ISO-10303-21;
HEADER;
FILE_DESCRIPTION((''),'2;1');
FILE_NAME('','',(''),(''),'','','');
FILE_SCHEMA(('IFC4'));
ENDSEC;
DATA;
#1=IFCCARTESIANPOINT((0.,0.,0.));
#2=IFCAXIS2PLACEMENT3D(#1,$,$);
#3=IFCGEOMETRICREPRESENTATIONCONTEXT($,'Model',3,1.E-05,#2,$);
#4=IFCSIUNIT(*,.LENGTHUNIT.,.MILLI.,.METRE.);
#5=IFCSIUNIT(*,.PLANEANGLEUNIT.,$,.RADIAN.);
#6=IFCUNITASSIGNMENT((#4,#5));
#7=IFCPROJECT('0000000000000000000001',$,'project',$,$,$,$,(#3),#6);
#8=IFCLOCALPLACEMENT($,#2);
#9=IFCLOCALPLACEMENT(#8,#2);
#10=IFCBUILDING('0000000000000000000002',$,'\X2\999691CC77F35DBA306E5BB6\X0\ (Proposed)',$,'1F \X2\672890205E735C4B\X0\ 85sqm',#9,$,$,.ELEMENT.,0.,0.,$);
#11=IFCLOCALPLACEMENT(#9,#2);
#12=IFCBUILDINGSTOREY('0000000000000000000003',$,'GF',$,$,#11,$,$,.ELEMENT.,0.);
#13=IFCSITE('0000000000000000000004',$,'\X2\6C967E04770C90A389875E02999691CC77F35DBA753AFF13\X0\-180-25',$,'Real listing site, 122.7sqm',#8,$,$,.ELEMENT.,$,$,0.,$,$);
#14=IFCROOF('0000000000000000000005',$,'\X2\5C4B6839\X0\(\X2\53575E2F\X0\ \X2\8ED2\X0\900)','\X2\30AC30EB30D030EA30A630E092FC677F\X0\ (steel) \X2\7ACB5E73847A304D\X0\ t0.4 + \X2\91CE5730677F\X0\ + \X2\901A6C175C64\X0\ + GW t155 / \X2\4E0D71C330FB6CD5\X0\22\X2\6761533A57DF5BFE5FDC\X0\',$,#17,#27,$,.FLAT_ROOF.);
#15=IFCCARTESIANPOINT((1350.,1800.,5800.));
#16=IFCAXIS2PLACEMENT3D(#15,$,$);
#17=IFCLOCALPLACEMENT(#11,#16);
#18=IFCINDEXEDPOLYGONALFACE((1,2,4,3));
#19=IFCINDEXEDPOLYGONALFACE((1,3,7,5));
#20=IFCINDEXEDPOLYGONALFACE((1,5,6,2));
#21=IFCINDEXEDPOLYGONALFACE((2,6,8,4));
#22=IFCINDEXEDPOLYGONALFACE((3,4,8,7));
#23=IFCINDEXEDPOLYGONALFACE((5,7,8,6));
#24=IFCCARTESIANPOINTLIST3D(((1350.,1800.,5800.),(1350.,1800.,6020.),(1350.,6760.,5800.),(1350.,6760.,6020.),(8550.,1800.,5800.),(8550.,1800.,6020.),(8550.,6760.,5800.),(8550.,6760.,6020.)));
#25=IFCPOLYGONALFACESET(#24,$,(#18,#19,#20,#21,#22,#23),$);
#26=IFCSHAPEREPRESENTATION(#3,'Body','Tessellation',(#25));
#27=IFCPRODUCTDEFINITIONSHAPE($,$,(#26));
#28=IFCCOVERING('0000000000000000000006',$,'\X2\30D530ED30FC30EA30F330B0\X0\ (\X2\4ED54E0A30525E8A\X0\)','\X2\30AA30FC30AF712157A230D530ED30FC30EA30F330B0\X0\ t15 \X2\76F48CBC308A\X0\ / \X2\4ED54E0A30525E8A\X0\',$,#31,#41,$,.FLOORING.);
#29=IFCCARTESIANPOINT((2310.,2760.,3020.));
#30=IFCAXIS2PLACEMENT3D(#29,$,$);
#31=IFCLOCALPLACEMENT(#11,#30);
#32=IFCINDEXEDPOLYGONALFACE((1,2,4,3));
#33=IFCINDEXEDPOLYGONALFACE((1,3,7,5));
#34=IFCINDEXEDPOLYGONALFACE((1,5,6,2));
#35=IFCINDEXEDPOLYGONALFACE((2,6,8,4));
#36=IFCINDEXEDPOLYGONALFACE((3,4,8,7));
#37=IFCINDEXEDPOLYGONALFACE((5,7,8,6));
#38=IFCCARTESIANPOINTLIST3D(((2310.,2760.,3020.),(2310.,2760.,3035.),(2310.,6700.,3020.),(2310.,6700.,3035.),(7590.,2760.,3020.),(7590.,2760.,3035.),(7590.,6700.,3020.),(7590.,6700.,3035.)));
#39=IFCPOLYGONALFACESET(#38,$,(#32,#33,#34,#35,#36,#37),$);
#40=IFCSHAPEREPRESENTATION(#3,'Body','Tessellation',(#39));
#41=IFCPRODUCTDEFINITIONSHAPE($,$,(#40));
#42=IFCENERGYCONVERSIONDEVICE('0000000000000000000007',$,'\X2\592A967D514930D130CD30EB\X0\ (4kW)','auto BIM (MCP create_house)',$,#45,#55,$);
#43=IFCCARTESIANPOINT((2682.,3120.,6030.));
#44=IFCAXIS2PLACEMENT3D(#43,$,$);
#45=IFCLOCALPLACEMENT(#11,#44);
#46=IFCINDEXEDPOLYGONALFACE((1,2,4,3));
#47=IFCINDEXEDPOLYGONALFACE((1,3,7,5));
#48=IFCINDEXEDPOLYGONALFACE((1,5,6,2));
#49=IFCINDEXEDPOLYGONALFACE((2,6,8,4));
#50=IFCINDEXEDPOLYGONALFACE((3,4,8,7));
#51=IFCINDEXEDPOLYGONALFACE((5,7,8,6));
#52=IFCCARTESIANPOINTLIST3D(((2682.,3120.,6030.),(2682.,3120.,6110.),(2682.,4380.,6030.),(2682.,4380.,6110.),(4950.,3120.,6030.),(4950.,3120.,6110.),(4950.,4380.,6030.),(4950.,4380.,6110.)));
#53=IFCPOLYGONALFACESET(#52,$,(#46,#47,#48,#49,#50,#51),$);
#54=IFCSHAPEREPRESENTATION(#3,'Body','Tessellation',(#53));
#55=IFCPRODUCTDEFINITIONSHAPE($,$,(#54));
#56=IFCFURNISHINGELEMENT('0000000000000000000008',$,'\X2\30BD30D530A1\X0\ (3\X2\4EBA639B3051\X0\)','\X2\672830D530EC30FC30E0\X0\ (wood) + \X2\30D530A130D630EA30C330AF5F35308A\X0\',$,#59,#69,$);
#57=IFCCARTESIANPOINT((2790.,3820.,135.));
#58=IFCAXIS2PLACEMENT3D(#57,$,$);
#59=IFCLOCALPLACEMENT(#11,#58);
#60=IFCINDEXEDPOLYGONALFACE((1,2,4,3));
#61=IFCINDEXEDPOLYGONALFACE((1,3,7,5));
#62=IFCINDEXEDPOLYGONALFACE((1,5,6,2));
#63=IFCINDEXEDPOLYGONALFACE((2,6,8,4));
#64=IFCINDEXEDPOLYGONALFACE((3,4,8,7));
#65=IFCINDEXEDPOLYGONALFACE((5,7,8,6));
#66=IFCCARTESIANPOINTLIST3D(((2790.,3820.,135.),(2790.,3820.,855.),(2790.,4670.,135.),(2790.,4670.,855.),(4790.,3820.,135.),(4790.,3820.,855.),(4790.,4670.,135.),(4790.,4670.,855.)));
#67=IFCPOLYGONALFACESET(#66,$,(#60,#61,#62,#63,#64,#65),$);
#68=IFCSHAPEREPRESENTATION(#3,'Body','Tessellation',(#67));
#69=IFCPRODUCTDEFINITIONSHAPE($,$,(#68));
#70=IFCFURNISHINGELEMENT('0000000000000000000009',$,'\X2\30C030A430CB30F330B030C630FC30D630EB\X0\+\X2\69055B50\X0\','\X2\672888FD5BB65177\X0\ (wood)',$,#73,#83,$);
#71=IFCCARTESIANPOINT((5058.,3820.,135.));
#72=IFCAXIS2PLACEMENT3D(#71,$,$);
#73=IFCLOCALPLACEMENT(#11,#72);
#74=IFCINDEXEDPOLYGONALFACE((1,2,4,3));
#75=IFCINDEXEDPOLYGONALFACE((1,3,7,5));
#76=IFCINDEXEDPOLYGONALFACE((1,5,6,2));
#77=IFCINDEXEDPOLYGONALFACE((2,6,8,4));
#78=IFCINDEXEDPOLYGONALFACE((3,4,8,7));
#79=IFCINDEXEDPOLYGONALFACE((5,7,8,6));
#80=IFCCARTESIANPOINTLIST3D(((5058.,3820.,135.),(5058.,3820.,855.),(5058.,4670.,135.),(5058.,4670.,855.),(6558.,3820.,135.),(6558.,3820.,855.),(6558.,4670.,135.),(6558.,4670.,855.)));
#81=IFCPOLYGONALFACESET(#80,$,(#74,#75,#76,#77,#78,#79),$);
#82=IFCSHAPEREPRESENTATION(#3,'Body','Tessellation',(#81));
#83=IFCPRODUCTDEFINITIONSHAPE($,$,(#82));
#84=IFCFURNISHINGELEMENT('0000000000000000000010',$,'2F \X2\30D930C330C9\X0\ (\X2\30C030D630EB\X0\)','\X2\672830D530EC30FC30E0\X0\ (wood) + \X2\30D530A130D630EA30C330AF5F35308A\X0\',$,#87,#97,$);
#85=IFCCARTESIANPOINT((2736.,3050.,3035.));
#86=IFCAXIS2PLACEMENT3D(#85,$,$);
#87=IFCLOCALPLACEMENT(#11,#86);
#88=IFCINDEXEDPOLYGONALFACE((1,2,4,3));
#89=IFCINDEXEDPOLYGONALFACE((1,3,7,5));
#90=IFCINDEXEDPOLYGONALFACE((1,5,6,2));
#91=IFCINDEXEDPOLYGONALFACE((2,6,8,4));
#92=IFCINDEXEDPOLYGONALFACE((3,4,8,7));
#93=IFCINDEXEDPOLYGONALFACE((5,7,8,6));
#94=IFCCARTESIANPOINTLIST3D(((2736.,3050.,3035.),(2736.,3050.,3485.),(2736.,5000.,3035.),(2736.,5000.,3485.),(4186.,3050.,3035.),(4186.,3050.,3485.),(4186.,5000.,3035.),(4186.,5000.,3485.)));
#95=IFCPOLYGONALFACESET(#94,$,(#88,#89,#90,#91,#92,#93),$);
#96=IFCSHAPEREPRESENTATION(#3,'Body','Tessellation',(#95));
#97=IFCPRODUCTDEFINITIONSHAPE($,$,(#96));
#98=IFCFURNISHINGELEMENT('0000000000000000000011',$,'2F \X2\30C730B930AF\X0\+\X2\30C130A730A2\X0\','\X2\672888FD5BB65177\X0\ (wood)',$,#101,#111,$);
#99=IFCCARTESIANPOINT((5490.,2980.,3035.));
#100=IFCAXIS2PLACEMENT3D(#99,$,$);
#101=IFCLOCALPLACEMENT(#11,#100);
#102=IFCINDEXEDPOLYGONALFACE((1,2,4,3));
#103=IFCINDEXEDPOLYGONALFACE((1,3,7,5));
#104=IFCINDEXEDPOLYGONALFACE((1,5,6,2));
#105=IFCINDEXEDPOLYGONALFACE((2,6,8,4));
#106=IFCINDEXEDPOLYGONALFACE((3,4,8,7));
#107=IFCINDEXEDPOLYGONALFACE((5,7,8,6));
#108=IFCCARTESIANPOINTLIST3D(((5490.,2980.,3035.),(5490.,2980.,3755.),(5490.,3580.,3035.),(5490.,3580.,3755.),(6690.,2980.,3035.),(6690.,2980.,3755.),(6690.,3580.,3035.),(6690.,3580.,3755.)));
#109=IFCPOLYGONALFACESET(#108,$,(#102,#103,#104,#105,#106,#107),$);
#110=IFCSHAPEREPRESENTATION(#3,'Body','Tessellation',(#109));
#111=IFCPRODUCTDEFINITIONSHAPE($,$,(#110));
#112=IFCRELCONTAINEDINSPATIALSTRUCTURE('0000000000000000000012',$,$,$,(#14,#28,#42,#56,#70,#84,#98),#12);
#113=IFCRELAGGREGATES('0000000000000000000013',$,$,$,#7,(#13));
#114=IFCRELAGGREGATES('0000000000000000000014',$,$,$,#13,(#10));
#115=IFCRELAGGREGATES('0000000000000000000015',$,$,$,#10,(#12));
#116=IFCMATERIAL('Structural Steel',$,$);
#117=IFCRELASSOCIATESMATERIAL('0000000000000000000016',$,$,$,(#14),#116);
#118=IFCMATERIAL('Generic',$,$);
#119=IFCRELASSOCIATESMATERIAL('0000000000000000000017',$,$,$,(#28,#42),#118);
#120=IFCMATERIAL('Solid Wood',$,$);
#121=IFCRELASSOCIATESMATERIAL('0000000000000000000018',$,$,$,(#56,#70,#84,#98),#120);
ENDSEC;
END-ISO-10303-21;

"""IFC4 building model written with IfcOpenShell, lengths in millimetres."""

from ifc_helpers import new_model, si_unit, frame, frame_2d, origin, place, context, project, spatial, rectangle, extrude, material, element, save


model = new_model("IFC4")

# Units and contexts
model_context = context("Model", 3, precision=1e-05, world=origin())
ifc_project = project(units=[si_unit("LENGTHUNIT", "METRE", prefix="MILLI"), si_unit("PLANEANGLEUNIT", "RADIAN")], contexts=[model_context])

# Site, building, storey
site_placement = place(None, origin())
site = spatial("IfcSite", under=ifc_project, at=site_placement, Name="沖縄県那覇市首里石嶺町３-180-25", ObjectType="Real listing site, 122.7sqm", CompositionType="ELEMENT", RefElevation=0.0)
building_placement = place(site_placement, origin())
building = spatial("IfcBuilding", under=site, at=building_placement, Name="首里石嶺の家 (Proposed)", ObjectType="1F 木造平屋 85sqm", CompositionType="ELEMENT", ElevationOfRefHeight=0.0, ElevationOfTerrain=0.0)
storey_placement = place(building_placement, origin())
storey = spatial("IfcBuildingStorey", under=building, at=storey_placement, Name="GF", CompositionType="ELEMENT", Elevation=0.0)

# Shared definitions
ifc_material_1 = material(Name="Solid Wood")

# Shared definitions
ifc_material_2 = material(Name="Generic")

# Roof
ifc_material_3 = material(Name="Structural Steel")
for number, where, name in (
    (1, (1350.0, 1800.0, 5800.0), "屋根(南帯 軒900)"),
):
    element("IfcRoof", number, at=place(storey_placement, frame(where)), inside=storey, material=ifc_material_3, Name=name, Description="ガルバリウム鋼板 (steel) 立平葺き t0.4 + 野地板 + 通気層 + GW t155 / 不燃・法22条区域対応", PredefinedType="FLAT_ROOF", context=model_context, shape_type="SweptSolid", body=[
        extrude(rectangle(XDim=7200.0, YDim=4960.0, at=frame_2d((3600.0, 2480.0))), frame((1350.0, 1800.0, 5800.0)), (0.0, 0.0, 1.0), 220.0),
    ])

# Covering
covering_placement = place(storey_placement, frame((2310.0, 2760.0, 3020.0)))
element("IfcCovering", 2, at=covering_placement, inside=storey, material=ifc_material_2, Name="フローリング (仕上げ床)", Description="オーク無垢フローリング t15 直貼り / 仕上げ床", PredefinedType="FLOORING", context=model_context, shape_type="SweptSolid", body=[
    extrude(rectangle(XDim=5280.0, YDim=3940.0, at=frame_2d((2640.0, 1970.0))), frame((2310.0, 2760.0, 3020.0)), (0.0, 0.0, 1.0), 15.0),
])

# Energy conversion device
energy_conversion_device_placement = place(storey_placement, frame((2682.0, 3120.0, 6030.0)))
element("IfcEnergyConversionDevice", 3, at=energy_conversion_device_placement, inside=storey, material=ifc_material_2, Name="太陽光パネル (4kW)", Description="auto BIM (MCP create_house)", context=model_context, shape_type="SweptSolid", body=[
    extrude(rectangle(XDim=2268.0, YDim=1260.0, at=frame_2d((1134.0, 630.0))), frame((2682.0, 3120.0, 6030.0)), (0.0, 0.0, 1.0), 80.0),
])

# Furnishing elements
furnishing_1_placement = place(storey_placement, frame((2790.0, 3820.0, 135.0)))
element("IfcFurnishingElement", 4, at=furnishing_1_placement, inside=storey, material=ifc_material_1, Name="ソファ (3人掛け)", Description="木フレーム (wood) + ファブリック張り", context=model_context, shape_type="SweptSolid", body=[
    extrude(rectangle(XDim=2000.0, YDim=850.0, at=frame_2d((1000.0, 425.0))), frame((2790.0, 3820.0, 135.0)), (0.0, 0.0, 1.0), 720.0),
])
furnishing_2_placement = place(storey_placement, frame((5058.0, 3820.0, 135.0)))
element("IfcFurnishingElement", 5, at=furnishing_2_placement, inside=storey, material=ifc_material_1, Name="ダイニングテーブル+椅子", Description="木製家具 (wood)", context=model_context, shape_type="SweptSolid", body=[
    extrude(rectangle(XDim=1500.0, YDim=850.0, at=frame_2d((750.0, 425.0))), frame((5058.0, 3820.0, 135.0)), (0.0, 0.0, 1.0), 720.0),
])
furnishing_3_placement = place(storey_placement, frame((2736.0, 3050.0, 3035.0)))
element("IfcFurnishingElement", 6, at=furnishing_3_placement, inside=storey, material=ifc_material_1, Name="2F ベッド (ダブル)", Description="木フレーム (wood) + ファブリック張り", context=model_context, shape_type="SweptSolid", body=[
    extrude(rectangle(XDim=1450.0, YDim=1950.0, at=frame_2d((725.0, 975.0))), frame((2736.0, 3050.0, 3035.0)), (0.0, 0.0, 1.0), 450.0),
])
furnishing_4_placement = place(storey_placement, frame((5490.0, 2980.0, 3035.0)))
element("IfcFurnishingElement", 7, at=furnishing_4_placement, inside=storey, material=ifc_material_1, Name="2F デスク+チェア", Description="木製家具 (wood)", context=model_context, shape_type="SweptSolid", body=[
    extrude(rectangle(XDim=1200.0, YDim=600.0, at=frame_2d((600.0, 300.0))), frame((5490.0, 2980.0, 3035.0)), (0.0, 0.0, 1.0), 720.0),
])

save(model, "model.ifc")
